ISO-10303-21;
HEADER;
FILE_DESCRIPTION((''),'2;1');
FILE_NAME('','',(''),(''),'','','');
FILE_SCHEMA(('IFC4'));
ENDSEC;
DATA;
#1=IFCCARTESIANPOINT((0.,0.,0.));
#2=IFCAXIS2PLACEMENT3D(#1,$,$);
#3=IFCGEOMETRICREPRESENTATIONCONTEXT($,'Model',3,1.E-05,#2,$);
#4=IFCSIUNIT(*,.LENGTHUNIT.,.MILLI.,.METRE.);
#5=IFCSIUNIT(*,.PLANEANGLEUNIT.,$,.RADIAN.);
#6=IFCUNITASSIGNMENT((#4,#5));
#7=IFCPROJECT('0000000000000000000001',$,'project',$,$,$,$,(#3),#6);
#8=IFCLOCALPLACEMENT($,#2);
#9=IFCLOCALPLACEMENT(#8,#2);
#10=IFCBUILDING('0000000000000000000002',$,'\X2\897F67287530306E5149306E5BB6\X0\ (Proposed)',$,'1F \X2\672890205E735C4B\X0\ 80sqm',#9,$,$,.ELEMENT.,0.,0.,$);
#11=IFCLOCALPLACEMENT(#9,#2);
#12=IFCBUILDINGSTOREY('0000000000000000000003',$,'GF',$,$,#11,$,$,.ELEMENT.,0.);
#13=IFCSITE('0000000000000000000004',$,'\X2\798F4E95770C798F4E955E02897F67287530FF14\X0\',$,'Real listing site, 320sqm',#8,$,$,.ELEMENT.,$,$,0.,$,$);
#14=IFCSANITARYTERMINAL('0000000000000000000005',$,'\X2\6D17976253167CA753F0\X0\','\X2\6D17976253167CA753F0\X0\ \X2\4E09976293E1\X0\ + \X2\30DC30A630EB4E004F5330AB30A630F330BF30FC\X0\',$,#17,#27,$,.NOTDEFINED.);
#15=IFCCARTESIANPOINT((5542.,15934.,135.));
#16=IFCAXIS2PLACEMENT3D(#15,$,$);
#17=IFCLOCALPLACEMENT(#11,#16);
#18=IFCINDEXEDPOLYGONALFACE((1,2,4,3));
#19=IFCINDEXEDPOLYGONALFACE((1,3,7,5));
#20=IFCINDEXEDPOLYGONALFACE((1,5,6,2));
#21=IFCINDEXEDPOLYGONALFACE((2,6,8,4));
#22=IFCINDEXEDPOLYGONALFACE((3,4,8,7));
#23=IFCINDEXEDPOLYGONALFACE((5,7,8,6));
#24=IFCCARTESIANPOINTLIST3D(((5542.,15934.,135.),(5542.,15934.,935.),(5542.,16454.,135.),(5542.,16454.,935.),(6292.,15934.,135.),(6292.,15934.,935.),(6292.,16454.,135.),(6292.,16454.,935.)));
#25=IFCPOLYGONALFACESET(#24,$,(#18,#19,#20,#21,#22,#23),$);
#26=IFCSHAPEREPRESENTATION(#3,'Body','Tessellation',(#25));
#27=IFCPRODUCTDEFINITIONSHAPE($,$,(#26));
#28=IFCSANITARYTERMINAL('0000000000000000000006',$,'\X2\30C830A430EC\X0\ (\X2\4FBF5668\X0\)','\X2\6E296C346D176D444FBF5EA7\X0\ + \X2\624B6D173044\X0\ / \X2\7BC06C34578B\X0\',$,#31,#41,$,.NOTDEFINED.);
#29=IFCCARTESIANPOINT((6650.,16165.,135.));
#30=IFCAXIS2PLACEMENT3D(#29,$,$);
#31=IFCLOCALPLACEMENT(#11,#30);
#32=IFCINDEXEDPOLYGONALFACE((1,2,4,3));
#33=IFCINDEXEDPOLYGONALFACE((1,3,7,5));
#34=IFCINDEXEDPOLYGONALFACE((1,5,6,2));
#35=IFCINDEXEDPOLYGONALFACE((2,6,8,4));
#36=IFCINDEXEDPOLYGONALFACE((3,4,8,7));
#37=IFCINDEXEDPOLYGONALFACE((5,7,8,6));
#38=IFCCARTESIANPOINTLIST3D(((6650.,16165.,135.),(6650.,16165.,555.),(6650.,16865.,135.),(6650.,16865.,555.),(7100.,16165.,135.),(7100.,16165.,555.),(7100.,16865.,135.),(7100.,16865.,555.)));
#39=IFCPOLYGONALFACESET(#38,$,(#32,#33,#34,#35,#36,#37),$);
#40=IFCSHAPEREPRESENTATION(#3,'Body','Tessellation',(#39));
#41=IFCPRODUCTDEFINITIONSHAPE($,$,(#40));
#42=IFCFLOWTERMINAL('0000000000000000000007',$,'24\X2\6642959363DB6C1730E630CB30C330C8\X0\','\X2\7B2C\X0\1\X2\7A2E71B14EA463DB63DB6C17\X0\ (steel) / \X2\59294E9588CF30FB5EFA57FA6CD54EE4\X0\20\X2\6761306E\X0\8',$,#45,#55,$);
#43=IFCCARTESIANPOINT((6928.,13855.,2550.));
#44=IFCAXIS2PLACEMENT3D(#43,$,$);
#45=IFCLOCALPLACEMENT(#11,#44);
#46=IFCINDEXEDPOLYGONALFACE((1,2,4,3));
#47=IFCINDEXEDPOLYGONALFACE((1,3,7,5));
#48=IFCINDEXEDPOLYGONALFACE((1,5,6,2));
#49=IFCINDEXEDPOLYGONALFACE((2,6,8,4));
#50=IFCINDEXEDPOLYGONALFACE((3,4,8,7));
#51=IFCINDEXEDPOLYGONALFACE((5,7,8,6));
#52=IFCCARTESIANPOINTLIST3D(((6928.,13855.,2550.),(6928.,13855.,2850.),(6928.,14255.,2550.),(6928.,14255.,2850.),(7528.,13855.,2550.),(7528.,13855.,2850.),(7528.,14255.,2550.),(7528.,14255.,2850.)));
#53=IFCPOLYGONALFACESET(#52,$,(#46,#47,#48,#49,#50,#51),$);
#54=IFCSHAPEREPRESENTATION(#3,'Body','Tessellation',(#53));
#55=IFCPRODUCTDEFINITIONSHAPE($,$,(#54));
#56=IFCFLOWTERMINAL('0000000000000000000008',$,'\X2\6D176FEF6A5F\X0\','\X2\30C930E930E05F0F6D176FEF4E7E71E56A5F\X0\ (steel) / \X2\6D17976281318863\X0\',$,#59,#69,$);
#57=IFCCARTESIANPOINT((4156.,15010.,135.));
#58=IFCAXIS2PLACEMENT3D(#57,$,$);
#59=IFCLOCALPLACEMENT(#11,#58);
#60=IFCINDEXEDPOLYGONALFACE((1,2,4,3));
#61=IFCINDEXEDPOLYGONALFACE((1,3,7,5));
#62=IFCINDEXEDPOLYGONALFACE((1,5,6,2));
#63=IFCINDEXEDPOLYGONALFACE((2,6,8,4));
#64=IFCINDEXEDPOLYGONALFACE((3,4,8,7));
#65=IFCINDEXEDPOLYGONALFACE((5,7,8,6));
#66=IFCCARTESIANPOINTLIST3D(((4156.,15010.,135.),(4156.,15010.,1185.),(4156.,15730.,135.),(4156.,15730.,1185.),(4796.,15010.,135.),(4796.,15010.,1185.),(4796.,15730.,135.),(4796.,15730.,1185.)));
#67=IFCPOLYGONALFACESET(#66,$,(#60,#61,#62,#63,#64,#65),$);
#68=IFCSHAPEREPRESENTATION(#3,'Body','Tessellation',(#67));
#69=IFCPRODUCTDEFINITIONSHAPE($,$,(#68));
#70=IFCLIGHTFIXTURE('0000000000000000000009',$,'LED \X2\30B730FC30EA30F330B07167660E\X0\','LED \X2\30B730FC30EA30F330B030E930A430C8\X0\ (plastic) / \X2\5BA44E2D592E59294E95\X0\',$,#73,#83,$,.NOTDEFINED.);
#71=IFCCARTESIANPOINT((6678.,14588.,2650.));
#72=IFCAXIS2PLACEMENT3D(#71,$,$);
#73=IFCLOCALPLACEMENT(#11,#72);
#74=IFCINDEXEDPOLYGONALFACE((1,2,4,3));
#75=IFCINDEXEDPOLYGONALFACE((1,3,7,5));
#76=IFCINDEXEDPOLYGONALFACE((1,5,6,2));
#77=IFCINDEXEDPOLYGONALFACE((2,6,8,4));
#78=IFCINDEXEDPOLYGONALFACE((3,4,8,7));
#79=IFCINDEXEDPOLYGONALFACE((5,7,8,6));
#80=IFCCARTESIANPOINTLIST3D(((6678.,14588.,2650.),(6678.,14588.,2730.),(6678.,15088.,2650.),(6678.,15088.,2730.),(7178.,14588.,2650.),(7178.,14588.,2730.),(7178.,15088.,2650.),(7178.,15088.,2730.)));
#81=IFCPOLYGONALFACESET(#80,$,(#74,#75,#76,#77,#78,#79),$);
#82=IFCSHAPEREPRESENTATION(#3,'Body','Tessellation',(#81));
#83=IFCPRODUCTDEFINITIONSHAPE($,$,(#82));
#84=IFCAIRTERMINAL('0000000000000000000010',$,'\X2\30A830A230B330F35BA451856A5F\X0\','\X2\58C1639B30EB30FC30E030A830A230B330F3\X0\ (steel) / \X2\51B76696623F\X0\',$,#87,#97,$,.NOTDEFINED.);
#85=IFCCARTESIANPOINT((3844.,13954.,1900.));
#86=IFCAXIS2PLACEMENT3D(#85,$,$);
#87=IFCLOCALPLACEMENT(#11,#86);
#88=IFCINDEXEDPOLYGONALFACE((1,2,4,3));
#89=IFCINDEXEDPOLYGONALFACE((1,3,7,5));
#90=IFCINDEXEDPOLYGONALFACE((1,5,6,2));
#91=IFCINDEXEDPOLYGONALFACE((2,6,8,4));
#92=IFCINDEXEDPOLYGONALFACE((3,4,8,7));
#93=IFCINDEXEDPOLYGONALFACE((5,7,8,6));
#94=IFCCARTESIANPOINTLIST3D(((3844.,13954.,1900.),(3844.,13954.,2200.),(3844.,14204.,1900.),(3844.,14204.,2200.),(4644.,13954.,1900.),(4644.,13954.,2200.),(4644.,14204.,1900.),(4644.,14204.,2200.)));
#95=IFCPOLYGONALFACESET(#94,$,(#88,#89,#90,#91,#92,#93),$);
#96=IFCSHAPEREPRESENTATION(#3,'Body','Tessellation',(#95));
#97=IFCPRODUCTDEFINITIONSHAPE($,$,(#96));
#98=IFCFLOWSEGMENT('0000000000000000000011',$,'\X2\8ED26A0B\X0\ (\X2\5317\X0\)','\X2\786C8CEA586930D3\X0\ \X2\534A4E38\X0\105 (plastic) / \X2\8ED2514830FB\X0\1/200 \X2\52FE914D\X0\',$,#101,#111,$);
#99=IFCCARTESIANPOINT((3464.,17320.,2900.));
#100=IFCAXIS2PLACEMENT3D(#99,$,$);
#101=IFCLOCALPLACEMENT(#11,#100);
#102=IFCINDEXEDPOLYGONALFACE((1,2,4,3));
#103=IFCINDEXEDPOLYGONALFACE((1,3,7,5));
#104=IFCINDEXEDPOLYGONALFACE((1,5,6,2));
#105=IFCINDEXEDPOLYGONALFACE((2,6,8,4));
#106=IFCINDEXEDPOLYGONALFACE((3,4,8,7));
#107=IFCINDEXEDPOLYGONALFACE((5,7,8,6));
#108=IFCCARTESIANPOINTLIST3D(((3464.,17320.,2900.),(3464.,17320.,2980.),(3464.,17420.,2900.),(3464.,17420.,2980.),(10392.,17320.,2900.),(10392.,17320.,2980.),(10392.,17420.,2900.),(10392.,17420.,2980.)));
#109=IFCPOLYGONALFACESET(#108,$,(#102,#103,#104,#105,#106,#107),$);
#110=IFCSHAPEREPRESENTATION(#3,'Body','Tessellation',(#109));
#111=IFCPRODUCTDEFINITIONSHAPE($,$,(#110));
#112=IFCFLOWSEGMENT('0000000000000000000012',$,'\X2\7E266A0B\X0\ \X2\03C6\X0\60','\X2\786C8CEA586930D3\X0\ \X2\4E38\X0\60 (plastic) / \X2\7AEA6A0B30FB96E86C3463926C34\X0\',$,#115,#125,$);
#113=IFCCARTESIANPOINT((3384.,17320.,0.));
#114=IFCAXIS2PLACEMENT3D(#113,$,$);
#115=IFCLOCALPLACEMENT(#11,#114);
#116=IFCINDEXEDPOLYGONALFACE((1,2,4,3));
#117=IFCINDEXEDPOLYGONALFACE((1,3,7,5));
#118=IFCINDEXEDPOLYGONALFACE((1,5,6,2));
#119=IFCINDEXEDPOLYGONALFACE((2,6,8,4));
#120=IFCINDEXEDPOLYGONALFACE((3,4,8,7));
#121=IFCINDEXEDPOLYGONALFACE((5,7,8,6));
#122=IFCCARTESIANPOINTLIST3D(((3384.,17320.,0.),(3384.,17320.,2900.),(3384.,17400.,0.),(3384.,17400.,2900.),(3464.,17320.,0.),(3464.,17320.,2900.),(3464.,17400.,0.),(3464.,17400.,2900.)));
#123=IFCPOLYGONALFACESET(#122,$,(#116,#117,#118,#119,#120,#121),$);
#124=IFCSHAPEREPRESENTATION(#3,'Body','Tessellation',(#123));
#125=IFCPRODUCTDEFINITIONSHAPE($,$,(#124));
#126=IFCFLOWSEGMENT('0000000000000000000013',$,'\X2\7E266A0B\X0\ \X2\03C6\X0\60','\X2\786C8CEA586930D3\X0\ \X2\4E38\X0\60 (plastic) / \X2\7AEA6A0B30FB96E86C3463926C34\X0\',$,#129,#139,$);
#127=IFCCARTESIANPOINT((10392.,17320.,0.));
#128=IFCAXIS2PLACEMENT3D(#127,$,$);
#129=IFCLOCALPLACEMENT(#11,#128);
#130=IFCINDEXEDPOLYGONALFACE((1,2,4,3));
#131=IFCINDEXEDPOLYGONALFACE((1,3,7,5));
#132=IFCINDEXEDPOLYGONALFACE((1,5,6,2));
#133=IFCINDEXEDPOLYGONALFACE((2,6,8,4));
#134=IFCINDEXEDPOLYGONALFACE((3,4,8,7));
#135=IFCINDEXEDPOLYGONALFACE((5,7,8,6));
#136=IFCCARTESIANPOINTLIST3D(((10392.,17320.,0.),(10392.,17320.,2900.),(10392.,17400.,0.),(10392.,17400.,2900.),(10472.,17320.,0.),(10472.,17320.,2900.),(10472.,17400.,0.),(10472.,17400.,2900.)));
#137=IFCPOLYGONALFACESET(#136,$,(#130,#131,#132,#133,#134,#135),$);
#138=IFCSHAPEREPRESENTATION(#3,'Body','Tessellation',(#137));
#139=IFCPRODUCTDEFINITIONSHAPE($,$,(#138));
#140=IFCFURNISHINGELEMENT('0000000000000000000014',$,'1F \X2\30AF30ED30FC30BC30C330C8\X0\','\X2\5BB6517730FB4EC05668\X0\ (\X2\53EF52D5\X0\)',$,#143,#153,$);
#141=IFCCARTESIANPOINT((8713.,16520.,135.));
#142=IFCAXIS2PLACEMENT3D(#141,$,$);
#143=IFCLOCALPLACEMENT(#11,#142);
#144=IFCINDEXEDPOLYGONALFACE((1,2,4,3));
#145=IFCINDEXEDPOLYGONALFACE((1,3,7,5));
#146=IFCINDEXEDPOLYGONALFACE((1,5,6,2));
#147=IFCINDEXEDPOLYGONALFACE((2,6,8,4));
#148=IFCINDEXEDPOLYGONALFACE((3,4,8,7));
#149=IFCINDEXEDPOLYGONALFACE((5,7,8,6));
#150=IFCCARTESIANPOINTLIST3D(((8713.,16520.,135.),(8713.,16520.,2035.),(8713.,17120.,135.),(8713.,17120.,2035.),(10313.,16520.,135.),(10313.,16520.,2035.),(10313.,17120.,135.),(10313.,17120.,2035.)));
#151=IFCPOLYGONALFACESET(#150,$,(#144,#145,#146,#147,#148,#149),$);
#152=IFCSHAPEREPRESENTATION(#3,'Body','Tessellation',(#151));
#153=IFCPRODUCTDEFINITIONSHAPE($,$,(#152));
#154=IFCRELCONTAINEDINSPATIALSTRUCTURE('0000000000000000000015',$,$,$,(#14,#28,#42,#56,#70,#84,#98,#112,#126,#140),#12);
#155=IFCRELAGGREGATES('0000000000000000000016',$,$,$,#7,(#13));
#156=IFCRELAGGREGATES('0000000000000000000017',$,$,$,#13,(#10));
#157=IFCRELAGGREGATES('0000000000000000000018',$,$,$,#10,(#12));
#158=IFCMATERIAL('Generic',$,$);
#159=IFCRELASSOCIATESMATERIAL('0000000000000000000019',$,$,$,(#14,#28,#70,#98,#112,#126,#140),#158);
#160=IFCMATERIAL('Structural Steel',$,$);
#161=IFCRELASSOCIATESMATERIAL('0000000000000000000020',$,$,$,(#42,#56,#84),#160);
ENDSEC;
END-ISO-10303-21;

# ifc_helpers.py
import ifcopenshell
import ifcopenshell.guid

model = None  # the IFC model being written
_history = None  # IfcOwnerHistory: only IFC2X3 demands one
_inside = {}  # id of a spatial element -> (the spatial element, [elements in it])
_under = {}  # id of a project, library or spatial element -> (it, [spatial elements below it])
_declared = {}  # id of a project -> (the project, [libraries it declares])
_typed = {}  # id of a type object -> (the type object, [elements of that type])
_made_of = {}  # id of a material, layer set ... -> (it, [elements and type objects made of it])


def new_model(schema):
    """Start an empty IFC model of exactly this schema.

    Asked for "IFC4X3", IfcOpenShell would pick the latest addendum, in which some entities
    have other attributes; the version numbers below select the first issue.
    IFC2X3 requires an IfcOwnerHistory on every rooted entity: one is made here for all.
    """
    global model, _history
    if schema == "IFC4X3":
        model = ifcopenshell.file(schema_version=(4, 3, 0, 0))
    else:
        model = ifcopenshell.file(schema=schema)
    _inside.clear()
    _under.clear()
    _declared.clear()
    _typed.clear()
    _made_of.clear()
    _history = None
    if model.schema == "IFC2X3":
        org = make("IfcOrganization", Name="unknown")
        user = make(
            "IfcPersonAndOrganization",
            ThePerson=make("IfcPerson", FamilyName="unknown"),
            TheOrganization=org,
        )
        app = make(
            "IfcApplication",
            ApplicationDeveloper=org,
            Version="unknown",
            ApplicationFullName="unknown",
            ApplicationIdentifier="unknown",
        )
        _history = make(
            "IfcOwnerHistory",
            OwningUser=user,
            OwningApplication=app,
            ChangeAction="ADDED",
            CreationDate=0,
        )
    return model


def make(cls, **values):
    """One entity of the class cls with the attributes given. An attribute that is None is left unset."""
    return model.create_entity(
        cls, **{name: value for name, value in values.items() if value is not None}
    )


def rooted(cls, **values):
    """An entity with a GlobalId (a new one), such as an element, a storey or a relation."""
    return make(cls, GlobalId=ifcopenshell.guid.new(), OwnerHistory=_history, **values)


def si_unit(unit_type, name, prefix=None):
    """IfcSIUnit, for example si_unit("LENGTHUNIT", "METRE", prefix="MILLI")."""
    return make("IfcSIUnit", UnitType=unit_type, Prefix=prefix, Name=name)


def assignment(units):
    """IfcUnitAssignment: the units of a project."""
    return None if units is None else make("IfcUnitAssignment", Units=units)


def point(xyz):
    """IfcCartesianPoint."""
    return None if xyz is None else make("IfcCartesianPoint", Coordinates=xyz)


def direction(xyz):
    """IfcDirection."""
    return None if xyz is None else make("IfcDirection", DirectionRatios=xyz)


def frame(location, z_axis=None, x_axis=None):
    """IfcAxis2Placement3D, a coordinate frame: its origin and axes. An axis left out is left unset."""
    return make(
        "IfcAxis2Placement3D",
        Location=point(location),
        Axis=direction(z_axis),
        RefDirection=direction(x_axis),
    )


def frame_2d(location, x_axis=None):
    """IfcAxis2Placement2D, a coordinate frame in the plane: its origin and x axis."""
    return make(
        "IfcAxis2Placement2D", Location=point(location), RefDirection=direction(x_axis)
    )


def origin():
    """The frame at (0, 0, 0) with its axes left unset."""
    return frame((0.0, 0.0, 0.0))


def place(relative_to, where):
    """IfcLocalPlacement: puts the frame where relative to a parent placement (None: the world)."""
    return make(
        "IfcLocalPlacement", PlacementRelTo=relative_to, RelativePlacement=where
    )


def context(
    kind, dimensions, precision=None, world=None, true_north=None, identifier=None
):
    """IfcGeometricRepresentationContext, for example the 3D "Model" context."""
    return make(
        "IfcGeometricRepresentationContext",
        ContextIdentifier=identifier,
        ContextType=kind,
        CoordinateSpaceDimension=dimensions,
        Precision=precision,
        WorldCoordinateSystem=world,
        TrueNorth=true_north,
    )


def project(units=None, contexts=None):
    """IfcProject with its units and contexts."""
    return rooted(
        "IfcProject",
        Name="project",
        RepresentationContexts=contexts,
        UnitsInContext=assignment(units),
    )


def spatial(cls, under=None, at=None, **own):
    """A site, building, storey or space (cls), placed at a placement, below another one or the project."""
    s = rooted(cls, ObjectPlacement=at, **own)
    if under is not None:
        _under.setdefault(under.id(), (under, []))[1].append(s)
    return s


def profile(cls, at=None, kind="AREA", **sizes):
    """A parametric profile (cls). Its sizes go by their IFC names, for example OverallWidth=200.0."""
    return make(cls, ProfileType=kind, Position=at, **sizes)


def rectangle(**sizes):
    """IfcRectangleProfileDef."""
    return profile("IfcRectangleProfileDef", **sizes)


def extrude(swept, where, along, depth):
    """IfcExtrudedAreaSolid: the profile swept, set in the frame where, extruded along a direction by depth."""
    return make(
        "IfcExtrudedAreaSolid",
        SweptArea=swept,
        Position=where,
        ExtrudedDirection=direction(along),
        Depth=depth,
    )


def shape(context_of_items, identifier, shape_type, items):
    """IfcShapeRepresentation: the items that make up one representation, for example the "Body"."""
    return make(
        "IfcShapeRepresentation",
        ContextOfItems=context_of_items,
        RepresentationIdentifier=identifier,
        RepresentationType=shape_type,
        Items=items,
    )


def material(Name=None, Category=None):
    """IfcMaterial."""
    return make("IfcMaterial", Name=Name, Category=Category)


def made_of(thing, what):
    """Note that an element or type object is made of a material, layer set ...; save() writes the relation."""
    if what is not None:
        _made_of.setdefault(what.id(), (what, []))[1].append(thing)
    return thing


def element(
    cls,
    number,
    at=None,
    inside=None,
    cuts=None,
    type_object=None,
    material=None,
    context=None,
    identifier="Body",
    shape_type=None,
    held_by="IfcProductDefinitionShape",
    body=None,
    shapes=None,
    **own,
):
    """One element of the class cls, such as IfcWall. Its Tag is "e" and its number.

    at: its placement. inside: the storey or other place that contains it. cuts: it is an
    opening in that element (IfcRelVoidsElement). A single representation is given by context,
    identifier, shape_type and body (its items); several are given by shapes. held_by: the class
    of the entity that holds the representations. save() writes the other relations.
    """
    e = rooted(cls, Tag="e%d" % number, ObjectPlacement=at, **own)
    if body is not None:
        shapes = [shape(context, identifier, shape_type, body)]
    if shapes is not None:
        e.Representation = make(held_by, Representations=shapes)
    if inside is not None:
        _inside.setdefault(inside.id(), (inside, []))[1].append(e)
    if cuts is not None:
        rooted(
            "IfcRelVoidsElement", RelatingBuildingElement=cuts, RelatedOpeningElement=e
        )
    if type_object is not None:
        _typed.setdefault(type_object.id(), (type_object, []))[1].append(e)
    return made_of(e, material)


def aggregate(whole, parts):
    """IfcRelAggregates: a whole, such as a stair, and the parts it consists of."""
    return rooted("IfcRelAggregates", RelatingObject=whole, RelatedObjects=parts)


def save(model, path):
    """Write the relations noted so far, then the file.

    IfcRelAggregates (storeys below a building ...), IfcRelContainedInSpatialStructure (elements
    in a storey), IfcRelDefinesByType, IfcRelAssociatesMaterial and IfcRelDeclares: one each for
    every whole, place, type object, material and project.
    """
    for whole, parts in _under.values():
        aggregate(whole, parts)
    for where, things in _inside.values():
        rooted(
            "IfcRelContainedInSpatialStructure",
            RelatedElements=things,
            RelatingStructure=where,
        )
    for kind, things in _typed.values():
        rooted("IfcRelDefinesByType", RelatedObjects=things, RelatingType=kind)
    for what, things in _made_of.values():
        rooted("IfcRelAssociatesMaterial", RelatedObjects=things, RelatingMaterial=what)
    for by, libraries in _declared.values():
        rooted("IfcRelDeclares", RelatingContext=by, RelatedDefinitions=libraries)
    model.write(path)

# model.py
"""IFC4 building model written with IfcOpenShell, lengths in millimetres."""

from ifc_helpers import new_model, si_unit, frame, frame_2d, origin, place, context, project, spatial, rectangle, extrude, material, element, save


model = new_model("IFC4")

# Units and contexts
model_context = context("Model", 3, precision=1e-05, world=origin())
ifc_project = project(units=[si_unit("LENGTHUNIT", "METRE", prefix="MILLI"), si_unit("PLANEANGLEUNIT", "RADIAN")], contexts=[model_context])

# Site, building, storey
site_placement = place(None, origin())
site = spatial("IfcSite", under=ifc_project, at=site_placement, Name="福井県福井市西木田４", ObjectType="Real listing site, 320sqm", CompositionType="ELEMENT", RefElevation=0.0)
building_placement = place(site_placement, origin())
building = spatial("IfcBuilding", under=site, at=building_placement, Name="西木田の光の家 (Proposed)", ObjectType="1F 木造平屋 80sqm", CompositionType="ELEMENT", ElevationOfRefHeight=0.0, ElevationOfTerrain=0.0)
storey_placement = place(building_placement, origin())
storey = spatial("IfcBuildingStorey", under=building, at=storey_placement, Name="GF", CompositionType="ELEMENT", Elevation=0.0)

# Shared definitions
ifc_material_1 = material(Name="Generic")

# Sanitary terminals
sanitary_terminal_1_placement = place(storey_placement, frame((5542.0, 15934.0, 135.0)))
element("IfcSanitaryTerminal", 1, at=sanitary_terminal_1_placement, inside=storey, material=ifc_material_1, Name="洗面化粧台", Description="洗面化粧台 三面鏡 + ボウル一体カウンター", PredefinedType="NOTDEFINED", context=model_context, shape_type="SweptSolid", body=[
    extrude(rectangle(XDim=750.0, YDim=520.0, at=frame_2d((375.0, 260.0))), frame((5542.0, 15934.0, 135.0)), (0.0, 0.0, 1.0), 800.0),
])
sanitary_terminal_2_placement = place(storey_placement, frame((6650.0, 16165.0, 135.0)))
element("IfcSanitaryTerminal", 2, at=sanitary_terminal_2_placement, inside=storey, material=ifc_material_1, Name="トイレ (便器)", Description="温水洗浄便座 + 手洗い / 節水型", PredefinedType="NOTDEFINED", context=model_context, shape_type="SweptSolid", body=[
    extrude(rectangle(XDim=450.0, YDim=700.0, at=frame_2d((225.0, 350.0))), frame((6650.0, 16165.0, 135.0)), (0.0, 0.0, 1.0), 420.0),
])

# Flow terminals
ifc_material_2 = material(Name="Structural Steel")
flow_terminal_1_placement = place(storey_placement, frame((6928.0, 13855.0, 2550.0)))
element("IfcFlowTerminal", 3, at=flow_terminal_1_placement, inside=storey, material=ifc_material_2, Name="24時間換気ユニット", Description="第1種熱交換換気 (steel) / 天井裏・建基法令20条の8", context=model_context, shape_type="SweptSolid", body=[
    extrude(rectangle(XDim=600.0, YDim=400.0, at=frame_2d((300.0, 200.0))), frame((6928.0, 13855.0, 2550.0)), (0.0, 0.0, 1.0), 300.0),
])
flow_terminal_2_placement = place(storey_placement, frame((4156.0, 15010.0, 135.0)))
element("IfcFlowTerminal", 4, at=flow_terminal_2_placement, inside=storey, material=ifc_material_2, Name="洗濯機", Description="ドラム式洗濯乾燥機 (steel) / 洗面脱衣", context=model_context, shape_type="SweptSolid", body=[
    extrude(rectangle(XDim=640.0, YDim=720.0, at=frame_2d((320.0, 360.0))), frame((4156.0, 15010.0, 135.0)), (0.0, 0.0, 1.0), 1050.0),
])

# Light fixture
light_fixture_placement = place(storey_placement, frame((6678.0, 14588.0, 2650.0)))
element("IfcLightFixture", 5, at=light_fixture_placement, inside=storey, material=ifc_material_1, Name="LED シーリング照明", Description="LED シーリングライト (plastic) / 室中央天井", PredefinedType="NOTDEFINED", context=model_context, shape_type="SweptSolid", body=[
    extrude(rectangle(XDim=500.0, YDim=500.0, at=frame_2d((250.0, 250.0))), frame((6678.0, 14588.0, 2650.0)), (0.0, 0.0, 1.0), 80.0),
])

# Air terminal
air_terminal_placement = place(storey_placement, frame((3844.0, 13954.0, 1900.0)))
element("IfcAirTerminal", 6, at=air_terminal_placement, inside=storey, material=ifc_material_2, Name="エアコン室内機", Description="壁掛ルームエアコン (steel) / 冷暖房", PredefinedType="NOTDEFINED", context=model_context, shape_type="SweptSolid", body=[
    extrude(rectangle(XDim=800.0, YDim=250.0, at=frame_2d((400.0, 125.0))), frame((3844.0, 13954.0, 1900.0)), (0.0, 0.0, 1.0), 300.0),
])

# Flow segments
flow_segment_1_placement = place(storey_placement, frame((3464.0, 17320.0, 2900.0)))
element("IfcFlowSegment", 7, at=flow_segment_1_placement, inside=storey, material=ifc_material_1, Name="軒樋 (北)", Description="硬質塩ビ 半丸105 (plastic) / 軒先・1/200 勾配", context=model_context, shape_type="SweptSolid", body=[
    extrude(rectangle(XDim=6928.0, YDim=100.0, at=frame_2d((3464.0, 50.0))), frame((3464.0, 17320.0, 2900.0)), (0.0, 0.0, 1.0), 80.0),
])
flow_segment_2_placement = place(storey_placement, frame((3384.0, 17320.0, 0.0)))
element("IfcFlowSegment", 8, at=flow_segment_2_placement, inside=storey, material=ifc_material_1, Name="縦樋 φ60", Description="硬質塩ビ 丸60 (plastic) / 竪樋・雨水排水", context=model_context, shape_type="SweptSolid", body=[
    extrude(rectangle(XDim=80.0, YDim=80.0, at=frame_2d((40.0, 40.0))), frame((3384.0, 17320.0, 0.0)), (0.0, 0.0, 1.0), 2900.0),
])
flow_segment_3_placement = place(storey_placement, frame((10392.0, 17320.0, 0.0)))
element("IfcFlowSegment", 9, at=flow_segment_3_placement, inside=storey, material=ifc_material_1, Name="縦樋 φ60", Description="硬質塩ビ 丸60 (plastic) / 竪樋・雨水排水", context=model_context, shape_type="SweptSolid", body=[
    extrude(rectangle(XDim=80.0, YDim=80.0, at=frame_2d((40.0, 40.0))), frame((10392.0, 17320.0, 0.0)), (0.0, 0.0, 1.0), 2900.0),
])

# Furnishing element
furnishing_placement = place(storey_placement, frame((8713.0, 16520.0, 135.0)))
element("IfcFurnishingElement", 10, at=furnishing_placement, inside=storey, material=ifc_material_1, Name="1F クローゼット", Description="家具・什器 (可動)", context=model_context, shape_type="SweptSolid", body=[
    extrude(rectangle(XDim=1600.0, YDim=600.0, at=frame_2d((800.0, 300.0))), frame((8713.0, 16520.0, 135.0)), (0.0, 0.0, 1.0), 1900.0),
])

save(model, "model.ifc")
